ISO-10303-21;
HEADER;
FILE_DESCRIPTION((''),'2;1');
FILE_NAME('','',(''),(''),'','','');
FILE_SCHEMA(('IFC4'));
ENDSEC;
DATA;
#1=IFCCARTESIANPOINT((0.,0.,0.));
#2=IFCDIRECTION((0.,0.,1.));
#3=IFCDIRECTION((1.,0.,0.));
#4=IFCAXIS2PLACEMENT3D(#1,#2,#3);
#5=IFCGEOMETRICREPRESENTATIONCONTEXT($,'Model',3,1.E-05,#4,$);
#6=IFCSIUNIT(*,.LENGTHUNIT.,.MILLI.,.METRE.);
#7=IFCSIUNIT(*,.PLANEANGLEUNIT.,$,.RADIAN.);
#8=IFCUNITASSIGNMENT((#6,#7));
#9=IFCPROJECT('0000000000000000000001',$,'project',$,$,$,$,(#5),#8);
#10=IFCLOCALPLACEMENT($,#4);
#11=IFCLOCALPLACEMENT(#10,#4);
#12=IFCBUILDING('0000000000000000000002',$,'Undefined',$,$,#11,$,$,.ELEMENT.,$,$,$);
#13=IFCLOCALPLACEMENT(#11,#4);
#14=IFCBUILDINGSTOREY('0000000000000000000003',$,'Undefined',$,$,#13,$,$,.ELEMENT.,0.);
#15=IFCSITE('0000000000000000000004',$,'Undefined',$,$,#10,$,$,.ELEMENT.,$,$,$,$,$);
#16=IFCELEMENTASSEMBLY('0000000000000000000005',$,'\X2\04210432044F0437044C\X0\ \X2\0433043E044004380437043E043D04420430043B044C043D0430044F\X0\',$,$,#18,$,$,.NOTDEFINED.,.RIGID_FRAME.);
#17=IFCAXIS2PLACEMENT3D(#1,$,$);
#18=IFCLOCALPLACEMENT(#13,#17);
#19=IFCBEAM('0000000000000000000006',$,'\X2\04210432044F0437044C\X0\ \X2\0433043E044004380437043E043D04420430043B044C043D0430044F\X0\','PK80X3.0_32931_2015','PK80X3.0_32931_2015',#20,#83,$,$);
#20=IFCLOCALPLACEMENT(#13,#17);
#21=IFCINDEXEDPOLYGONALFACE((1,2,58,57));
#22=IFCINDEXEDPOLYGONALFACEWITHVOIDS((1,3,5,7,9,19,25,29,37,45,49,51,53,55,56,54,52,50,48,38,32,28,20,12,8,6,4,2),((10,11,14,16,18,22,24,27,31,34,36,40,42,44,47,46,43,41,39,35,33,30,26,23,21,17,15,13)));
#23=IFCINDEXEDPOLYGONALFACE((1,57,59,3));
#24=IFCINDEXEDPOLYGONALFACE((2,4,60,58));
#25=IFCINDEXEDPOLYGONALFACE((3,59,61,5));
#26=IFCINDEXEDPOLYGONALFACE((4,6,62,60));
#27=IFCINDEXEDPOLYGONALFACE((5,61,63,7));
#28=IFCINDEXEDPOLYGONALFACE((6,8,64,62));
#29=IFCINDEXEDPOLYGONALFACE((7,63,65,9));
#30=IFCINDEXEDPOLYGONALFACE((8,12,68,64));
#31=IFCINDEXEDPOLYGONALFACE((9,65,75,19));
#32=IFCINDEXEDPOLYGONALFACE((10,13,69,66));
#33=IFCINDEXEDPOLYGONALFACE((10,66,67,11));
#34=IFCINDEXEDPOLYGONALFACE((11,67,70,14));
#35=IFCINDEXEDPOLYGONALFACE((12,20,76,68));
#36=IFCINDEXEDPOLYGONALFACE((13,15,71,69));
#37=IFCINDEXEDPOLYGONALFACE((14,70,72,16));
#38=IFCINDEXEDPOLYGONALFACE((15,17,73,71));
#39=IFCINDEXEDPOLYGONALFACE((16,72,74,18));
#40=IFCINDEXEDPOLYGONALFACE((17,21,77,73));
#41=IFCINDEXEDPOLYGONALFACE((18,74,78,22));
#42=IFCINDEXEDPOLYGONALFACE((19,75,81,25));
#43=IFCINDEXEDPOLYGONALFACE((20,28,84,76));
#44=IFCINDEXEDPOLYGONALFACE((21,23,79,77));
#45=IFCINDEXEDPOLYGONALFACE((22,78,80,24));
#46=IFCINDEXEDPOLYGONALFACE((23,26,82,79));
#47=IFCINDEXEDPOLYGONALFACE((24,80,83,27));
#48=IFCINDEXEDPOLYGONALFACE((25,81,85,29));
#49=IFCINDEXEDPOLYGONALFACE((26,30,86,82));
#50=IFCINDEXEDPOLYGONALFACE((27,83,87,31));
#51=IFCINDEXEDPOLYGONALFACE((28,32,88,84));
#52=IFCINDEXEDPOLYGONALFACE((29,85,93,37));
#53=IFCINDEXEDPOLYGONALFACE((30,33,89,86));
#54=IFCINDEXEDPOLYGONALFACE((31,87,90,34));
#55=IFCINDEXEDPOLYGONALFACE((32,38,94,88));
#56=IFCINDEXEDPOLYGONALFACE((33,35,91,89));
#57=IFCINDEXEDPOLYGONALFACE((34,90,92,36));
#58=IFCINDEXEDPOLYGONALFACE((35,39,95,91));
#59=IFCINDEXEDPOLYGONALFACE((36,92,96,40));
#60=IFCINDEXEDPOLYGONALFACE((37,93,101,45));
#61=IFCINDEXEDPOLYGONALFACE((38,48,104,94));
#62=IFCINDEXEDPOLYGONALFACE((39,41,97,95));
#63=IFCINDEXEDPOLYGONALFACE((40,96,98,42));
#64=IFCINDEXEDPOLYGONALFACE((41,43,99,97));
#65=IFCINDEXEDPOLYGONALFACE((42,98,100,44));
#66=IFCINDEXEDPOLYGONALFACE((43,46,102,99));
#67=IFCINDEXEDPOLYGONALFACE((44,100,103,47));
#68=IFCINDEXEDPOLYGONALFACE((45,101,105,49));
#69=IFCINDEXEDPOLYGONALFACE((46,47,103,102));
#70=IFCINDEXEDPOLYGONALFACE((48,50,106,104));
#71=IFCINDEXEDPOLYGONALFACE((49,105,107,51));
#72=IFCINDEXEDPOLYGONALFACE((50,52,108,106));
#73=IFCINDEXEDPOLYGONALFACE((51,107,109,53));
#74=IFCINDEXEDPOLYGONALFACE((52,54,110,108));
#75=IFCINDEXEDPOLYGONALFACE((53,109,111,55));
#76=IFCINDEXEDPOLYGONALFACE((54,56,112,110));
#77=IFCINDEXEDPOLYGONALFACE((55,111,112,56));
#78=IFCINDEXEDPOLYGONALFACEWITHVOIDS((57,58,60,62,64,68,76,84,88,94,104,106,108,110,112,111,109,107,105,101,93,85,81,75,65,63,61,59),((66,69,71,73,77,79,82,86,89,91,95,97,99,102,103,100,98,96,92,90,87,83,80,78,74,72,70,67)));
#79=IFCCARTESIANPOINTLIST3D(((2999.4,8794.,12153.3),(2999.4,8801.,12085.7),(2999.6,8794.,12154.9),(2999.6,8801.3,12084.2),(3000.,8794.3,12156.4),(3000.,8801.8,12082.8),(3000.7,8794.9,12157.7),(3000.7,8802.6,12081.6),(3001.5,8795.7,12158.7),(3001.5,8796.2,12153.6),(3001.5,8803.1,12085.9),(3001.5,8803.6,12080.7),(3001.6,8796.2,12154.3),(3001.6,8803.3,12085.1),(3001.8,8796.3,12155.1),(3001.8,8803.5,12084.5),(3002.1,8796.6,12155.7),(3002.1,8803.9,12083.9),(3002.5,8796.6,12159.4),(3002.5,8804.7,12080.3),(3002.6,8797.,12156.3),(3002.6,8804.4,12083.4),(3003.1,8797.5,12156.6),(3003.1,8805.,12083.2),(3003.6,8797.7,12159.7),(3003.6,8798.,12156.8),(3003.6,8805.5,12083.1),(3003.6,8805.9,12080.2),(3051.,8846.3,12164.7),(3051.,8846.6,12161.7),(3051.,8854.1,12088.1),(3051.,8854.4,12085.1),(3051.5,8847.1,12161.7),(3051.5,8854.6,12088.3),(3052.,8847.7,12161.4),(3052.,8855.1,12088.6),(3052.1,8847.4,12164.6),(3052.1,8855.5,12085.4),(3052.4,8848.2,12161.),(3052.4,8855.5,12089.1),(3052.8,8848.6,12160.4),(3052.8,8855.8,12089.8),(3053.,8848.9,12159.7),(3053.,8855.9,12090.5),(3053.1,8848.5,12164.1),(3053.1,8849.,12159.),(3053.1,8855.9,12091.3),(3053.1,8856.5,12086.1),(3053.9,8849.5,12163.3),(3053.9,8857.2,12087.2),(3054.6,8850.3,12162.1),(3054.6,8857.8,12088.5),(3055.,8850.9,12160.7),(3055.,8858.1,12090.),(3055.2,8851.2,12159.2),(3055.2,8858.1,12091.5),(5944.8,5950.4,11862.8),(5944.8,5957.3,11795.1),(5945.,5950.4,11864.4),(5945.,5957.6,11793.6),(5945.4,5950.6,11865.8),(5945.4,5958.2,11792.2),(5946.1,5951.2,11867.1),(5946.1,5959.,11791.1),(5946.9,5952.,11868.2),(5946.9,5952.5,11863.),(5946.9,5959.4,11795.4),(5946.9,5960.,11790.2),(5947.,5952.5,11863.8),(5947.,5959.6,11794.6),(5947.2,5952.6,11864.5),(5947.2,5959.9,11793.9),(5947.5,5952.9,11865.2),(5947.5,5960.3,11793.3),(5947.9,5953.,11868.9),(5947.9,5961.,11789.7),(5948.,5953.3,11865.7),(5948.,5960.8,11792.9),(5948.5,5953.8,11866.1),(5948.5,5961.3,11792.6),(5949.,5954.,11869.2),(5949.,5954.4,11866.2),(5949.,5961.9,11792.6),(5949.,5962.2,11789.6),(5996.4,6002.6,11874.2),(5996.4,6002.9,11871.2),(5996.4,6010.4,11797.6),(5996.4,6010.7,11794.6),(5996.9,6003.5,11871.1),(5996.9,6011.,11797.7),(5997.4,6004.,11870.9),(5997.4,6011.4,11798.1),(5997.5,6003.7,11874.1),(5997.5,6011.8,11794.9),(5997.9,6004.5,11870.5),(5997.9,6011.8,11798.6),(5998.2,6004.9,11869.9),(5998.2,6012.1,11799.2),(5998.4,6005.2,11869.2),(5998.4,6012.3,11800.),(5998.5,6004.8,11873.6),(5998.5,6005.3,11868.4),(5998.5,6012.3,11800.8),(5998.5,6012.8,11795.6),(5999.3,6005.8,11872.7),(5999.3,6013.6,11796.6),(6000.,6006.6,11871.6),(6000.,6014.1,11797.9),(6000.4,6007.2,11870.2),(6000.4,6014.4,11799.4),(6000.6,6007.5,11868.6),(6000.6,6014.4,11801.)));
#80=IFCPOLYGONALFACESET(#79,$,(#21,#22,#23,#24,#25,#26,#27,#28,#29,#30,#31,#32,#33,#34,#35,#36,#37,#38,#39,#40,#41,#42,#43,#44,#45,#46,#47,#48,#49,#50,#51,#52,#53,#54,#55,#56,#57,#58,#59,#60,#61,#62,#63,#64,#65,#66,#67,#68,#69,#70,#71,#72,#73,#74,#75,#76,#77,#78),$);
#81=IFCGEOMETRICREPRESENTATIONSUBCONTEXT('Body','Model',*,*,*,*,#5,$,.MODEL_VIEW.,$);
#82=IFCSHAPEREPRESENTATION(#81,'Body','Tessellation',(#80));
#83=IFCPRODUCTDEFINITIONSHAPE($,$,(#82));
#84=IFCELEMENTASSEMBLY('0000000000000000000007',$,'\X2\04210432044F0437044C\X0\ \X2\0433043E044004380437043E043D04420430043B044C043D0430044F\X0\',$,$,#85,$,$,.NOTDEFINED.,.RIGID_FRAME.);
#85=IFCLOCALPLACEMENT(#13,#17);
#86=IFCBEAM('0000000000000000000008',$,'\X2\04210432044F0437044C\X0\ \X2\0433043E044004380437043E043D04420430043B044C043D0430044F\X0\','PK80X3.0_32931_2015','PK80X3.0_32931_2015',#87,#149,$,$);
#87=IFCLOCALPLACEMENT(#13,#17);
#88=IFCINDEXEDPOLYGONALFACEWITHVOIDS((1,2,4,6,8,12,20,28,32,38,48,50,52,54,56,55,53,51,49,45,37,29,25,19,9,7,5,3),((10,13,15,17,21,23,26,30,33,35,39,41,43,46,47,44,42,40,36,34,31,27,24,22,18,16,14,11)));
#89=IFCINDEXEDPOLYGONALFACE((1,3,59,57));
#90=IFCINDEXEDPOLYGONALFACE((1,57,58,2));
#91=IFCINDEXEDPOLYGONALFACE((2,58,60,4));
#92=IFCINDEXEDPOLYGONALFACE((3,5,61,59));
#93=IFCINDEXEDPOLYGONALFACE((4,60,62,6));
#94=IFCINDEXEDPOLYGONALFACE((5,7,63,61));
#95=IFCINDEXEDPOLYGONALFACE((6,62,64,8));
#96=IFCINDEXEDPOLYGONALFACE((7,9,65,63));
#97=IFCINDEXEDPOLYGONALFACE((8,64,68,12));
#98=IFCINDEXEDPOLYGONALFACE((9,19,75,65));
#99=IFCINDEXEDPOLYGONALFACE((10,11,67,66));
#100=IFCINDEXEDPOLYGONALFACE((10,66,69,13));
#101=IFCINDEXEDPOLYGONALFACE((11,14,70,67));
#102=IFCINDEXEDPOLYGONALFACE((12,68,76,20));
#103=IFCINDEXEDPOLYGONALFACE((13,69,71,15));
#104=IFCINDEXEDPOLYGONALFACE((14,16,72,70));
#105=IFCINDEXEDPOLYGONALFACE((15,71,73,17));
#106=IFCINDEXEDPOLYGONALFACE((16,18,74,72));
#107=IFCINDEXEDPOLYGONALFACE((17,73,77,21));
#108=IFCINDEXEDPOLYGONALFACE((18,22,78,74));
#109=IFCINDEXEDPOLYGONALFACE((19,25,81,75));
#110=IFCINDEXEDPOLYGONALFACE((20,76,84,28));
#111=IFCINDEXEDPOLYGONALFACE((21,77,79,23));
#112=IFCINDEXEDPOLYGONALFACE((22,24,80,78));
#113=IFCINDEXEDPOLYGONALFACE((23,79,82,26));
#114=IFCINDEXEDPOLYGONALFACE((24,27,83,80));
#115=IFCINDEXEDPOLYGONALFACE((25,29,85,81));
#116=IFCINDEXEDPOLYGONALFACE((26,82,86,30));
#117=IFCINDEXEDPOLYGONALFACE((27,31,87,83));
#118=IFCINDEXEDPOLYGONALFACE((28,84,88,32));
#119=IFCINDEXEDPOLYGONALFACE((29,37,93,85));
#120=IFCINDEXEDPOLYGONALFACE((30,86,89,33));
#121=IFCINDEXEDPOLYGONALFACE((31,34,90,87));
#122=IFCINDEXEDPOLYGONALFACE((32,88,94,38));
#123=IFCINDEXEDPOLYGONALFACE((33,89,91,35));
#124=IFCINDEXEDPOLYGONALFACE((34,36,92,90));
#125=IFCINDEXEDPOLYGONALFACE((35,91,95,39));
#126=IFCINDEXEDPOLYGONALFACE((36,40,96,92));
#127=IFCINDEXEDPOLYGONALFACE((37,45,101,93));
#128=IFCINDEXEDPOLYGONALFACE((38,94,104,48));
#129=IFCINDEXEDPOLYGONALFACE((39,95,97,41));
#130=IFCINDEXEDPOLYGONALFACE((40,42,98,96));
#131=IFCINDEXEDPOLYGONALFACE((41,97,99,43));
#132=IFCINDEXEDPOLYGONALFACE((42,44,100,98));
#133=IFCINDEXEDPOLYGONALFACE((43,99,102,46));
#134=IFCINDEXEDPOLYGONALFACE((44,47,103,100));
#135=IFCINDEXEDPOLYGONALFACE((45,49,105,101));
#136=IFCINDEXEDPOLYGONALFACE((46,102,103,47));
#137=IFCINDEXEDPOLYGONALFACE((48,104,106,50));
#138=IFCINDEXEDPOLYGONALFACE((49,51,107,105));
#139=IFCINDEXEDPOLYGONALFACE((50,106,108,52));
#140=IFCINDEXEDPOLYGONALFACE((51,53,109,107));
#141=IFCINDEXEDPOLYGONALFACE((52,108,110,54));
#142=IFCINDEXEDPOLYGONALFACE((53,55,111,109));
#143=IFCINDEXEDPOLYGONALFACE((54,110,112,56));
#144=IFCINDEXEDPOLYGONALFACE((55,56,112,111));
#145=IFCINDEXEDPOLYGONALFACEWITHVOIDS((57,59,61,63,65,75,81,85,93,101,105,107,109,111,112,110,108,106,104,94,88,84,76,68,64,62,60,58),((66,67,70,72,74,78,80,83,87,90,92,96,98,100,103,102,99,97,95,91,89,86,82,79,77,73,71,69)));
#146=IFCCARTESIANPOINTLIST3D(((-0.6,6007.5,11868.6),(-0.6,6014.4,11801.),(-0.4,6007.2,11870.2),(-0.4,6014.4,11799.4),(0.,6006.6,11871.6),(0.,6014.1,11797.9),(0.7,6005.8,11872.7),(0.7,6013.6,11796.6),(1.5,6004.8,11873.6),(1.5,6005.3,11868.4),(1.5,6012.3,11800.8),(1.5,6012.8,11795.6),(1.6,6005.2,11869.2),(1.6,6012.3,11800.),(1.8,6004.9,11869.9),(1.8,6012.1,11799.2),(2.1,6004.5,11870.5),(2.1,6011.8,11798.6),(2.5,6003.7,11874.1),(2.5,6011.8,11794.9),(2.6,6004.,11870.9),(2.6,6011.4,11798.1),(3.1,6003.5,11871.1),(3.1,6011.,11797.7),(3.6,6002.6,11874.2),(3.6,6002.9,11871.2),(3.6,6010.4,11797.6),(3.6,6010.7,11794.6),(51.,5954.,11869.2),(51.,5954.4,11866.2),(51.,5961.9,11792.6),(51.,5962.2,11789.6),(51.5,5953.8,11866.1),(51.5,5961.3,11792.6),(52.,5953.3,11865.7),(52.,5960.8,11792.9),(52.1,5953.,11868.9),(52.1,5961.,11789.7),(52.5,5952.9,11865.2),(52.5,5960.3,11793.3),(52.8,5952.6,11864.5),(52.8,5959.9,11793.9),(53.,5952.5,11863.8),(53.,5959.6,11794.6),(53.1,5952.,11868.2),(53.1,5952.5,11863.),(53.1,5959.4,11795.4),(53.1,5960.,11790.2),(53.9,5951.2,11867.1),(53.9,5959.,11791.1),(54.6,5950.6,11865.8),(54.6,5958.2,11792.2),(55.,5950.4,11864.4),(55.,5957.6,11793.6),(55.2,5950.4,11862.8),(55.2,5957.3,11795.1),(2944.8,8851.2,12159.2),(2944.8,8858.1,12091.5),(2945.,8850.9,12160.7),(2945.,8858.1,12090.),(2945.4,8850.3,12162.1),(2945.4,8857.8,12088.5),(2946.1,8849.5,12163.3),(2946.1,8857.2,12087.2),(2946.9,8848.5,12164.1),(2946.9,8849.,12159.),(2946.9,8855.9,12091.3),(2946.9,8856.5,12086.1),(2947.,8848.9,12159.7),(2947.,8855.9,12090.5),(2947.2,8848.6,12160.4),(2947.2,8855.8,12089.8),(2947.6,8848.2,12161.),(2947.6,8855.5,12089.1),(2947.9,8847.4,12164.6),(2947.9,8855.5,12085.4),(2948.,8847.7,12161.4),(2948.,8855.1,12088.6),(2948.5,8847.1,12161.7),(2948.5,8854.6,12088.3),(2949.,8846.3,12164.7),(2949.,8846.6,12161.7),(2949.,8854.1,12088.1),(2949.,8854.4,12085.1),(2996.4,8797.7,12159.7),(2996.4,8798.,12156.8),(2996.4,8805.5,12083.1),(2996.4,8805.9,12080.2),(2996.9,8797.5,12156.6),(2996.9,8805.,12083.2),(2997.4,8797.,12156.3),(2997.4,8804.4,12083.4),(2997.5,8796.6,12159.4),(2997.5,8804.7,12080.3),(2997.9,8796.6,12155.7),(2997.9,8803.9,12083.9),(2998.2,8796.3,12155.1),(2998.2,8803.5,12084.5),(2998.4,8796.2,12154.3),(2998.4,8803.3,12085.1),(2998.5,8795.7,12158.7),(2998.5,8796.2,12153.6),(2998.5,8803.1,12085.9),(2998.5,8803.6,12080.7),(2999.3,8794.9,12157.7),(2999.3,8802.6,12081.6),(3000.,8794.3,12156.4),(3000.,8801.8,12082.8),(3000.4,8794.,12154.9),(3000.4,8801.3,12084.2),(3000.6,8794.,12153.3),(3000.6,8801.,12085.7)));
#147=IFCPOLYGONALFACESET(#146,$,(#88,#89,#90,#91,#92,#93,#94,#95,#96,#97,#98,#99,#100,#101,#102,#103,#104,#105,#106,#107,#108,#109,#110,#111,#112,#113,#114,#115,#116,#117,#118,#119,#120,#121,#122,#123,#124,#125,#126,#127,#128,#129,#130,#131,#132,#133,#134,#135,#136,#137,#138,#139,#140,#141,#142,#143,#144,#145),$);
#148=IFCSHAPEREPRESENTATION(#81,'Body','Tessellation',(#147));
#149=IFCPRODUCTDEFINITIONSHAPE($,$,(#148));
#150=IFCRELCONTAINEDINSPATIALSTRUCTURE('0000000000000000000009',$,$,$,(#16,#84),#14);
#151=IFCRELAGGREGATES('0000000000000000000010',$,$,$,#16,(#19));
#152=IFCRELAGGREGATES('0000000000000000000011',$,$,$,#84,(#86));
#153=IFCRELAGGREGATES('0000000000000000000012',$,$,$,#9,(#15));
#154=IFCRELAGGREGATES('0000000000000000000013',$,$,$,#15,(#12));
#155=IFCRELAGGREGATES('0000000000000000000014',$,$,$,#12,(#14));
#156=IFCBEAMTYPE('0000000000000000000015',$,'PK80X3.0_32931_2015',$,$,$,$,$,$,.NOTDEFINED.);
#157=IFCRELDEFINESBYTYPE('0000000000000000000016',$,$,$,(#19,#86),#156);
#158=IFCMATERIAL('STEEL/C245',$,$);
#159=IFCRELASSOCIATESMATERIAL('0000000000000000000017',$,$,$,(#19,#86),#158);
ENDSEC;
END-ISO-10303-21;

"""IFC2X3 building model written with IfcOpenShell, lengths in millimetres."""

from ifc_helpers import new_model, si_unit, frame, origin_with_axes, origin_2d_with_axis, place, context, subcontext, project, spatial, hollow_rectangle, extrude, material, type_object, element, aggregate, save


model = new_model("IFC2X3")

# Units and contexts
model_context = context("Model", 3, precision=1e-05, world=origin_with_axes())
body_context = subcontext(model_context, "Body", "Model", "MODEL_VIEW")
ifc_project = project(units=[si_unit("LENGTHUNIT", "METRE", prefix="MILLI"), si_unit("PLANEANGLEUNIT", "RADIAN")], contexts=[model_context])

# Site, building, storey
site_placement = place(None, origin_with_axes())
site = spatial("IfcSite", under=ifc_project, at=site_placement, Name="Undefined", CompositionType="ELEMENT")
building_placement = place(site_placement, origin_with_axes())
building = spatial("IfcBuilding", under=site, at=building_placement, Name="Undefined", CompositionType="ELEMENT")
storey_placement = place(building_placement, origin_with_axes())
storey = spatial("IfcBuildingStorey", under=building, at=storey_placement, Name="Undefined", CompositionType="ELEMENT", Elevation=0.0)

# Element assemblies, beams
ifc_material_1 = material(Name="STEEL/C245")
beam_type_1 = type_object("IfcBeamType", Name="PK80X3.0_32931_2015", PredefinedType="NOTDEFINED")
assembly_1_placement = place(storey_placement, origin_with_axes())
assembly_1 = element("IfcElementAssembly", 1, at=assembly_1_placement, inside=storey, Name="Связь горизонтальная", AssemblyPlace="NOTDEFINED", PredefinedType="RIGID_FRAME")
beam_1_placement = place(assembly_1_placement, frame((5972.7, 5982.4, 11831.9), z_axis=(0.0, -0.101645, 0.994821), x_axis=(-0.717617, 0.69283, 0.070789)))
beam_1 = element("IfcBeam", 2, at=beam_1_placement, type_object=beam_type_1, material=ifc_material_1, Name="Связь горизонтальная", Description="PK80X3.0_32931_2015", ObjectType="PK80X3.0_32931_2015", context=body_context, shape_type="SweptSolid", body=[
    extrude(hollow_rectangle(XDim=80.0, YDim=80.0, WallThickness=3.0, InnerFilletRadius=3.0, OuterFilletRadius=6.0, at=origin_2d_with_axis()), frame((4104.4, 0.0, 0.0), z_axis=(-1.0, 0.0, 0.0), x_axis=(0.0, -1.0, 0.0)), (0.0, 0.0, 1.0), 4104.4),
])
aggregate(assembly_1, [beam_1])
assembly_2_placement = place(storey_placement, origin_with_axes())
assembly_2 = element("IfcElementAssembly", 3, at=assembly_2_placement, inside=storey, Name="Связь горизонтальная", AssemblyPlace="NOTDEFINED", PredefinedType="RIGID_FRAME")
beam_2_placement = place(assembly_2_placement, frame((27.3, 5982.4, 11831.9), z_axis=(0.0, -0.101645, 0.994821), x_axis=(0.717617, 0.69283, 0.070789)))
beam_2 = element("IfcBeam", 4, at=beam_2_placement, type_object=beam_type_1, material=ifc_material_1, Name="Связь горизонтальная", Description="PK80X3.0_32931_2015", ObjectType="PK80X3.0_32931_2015", context=body_context, shape_type="SweptSolid", body=[
    extrude(hollow_rectangle(XDim=80.0, YDim=80.0, WallThickness=3.0, InnerFilletRadius=3.0, OuterFilletRadius=6.0, at=origin_2d_with_axis()), frame((4104.4, 0.0, 0.0), z_axis=(-1.0, 0.0, 0.0), x_axis=(0.0, -1.0, 0.0)), (0.0, 0.0, 1.0), 4104.4),
])
aggregate(assembly_2, [beam_2])

save(model, "model.ifc")
